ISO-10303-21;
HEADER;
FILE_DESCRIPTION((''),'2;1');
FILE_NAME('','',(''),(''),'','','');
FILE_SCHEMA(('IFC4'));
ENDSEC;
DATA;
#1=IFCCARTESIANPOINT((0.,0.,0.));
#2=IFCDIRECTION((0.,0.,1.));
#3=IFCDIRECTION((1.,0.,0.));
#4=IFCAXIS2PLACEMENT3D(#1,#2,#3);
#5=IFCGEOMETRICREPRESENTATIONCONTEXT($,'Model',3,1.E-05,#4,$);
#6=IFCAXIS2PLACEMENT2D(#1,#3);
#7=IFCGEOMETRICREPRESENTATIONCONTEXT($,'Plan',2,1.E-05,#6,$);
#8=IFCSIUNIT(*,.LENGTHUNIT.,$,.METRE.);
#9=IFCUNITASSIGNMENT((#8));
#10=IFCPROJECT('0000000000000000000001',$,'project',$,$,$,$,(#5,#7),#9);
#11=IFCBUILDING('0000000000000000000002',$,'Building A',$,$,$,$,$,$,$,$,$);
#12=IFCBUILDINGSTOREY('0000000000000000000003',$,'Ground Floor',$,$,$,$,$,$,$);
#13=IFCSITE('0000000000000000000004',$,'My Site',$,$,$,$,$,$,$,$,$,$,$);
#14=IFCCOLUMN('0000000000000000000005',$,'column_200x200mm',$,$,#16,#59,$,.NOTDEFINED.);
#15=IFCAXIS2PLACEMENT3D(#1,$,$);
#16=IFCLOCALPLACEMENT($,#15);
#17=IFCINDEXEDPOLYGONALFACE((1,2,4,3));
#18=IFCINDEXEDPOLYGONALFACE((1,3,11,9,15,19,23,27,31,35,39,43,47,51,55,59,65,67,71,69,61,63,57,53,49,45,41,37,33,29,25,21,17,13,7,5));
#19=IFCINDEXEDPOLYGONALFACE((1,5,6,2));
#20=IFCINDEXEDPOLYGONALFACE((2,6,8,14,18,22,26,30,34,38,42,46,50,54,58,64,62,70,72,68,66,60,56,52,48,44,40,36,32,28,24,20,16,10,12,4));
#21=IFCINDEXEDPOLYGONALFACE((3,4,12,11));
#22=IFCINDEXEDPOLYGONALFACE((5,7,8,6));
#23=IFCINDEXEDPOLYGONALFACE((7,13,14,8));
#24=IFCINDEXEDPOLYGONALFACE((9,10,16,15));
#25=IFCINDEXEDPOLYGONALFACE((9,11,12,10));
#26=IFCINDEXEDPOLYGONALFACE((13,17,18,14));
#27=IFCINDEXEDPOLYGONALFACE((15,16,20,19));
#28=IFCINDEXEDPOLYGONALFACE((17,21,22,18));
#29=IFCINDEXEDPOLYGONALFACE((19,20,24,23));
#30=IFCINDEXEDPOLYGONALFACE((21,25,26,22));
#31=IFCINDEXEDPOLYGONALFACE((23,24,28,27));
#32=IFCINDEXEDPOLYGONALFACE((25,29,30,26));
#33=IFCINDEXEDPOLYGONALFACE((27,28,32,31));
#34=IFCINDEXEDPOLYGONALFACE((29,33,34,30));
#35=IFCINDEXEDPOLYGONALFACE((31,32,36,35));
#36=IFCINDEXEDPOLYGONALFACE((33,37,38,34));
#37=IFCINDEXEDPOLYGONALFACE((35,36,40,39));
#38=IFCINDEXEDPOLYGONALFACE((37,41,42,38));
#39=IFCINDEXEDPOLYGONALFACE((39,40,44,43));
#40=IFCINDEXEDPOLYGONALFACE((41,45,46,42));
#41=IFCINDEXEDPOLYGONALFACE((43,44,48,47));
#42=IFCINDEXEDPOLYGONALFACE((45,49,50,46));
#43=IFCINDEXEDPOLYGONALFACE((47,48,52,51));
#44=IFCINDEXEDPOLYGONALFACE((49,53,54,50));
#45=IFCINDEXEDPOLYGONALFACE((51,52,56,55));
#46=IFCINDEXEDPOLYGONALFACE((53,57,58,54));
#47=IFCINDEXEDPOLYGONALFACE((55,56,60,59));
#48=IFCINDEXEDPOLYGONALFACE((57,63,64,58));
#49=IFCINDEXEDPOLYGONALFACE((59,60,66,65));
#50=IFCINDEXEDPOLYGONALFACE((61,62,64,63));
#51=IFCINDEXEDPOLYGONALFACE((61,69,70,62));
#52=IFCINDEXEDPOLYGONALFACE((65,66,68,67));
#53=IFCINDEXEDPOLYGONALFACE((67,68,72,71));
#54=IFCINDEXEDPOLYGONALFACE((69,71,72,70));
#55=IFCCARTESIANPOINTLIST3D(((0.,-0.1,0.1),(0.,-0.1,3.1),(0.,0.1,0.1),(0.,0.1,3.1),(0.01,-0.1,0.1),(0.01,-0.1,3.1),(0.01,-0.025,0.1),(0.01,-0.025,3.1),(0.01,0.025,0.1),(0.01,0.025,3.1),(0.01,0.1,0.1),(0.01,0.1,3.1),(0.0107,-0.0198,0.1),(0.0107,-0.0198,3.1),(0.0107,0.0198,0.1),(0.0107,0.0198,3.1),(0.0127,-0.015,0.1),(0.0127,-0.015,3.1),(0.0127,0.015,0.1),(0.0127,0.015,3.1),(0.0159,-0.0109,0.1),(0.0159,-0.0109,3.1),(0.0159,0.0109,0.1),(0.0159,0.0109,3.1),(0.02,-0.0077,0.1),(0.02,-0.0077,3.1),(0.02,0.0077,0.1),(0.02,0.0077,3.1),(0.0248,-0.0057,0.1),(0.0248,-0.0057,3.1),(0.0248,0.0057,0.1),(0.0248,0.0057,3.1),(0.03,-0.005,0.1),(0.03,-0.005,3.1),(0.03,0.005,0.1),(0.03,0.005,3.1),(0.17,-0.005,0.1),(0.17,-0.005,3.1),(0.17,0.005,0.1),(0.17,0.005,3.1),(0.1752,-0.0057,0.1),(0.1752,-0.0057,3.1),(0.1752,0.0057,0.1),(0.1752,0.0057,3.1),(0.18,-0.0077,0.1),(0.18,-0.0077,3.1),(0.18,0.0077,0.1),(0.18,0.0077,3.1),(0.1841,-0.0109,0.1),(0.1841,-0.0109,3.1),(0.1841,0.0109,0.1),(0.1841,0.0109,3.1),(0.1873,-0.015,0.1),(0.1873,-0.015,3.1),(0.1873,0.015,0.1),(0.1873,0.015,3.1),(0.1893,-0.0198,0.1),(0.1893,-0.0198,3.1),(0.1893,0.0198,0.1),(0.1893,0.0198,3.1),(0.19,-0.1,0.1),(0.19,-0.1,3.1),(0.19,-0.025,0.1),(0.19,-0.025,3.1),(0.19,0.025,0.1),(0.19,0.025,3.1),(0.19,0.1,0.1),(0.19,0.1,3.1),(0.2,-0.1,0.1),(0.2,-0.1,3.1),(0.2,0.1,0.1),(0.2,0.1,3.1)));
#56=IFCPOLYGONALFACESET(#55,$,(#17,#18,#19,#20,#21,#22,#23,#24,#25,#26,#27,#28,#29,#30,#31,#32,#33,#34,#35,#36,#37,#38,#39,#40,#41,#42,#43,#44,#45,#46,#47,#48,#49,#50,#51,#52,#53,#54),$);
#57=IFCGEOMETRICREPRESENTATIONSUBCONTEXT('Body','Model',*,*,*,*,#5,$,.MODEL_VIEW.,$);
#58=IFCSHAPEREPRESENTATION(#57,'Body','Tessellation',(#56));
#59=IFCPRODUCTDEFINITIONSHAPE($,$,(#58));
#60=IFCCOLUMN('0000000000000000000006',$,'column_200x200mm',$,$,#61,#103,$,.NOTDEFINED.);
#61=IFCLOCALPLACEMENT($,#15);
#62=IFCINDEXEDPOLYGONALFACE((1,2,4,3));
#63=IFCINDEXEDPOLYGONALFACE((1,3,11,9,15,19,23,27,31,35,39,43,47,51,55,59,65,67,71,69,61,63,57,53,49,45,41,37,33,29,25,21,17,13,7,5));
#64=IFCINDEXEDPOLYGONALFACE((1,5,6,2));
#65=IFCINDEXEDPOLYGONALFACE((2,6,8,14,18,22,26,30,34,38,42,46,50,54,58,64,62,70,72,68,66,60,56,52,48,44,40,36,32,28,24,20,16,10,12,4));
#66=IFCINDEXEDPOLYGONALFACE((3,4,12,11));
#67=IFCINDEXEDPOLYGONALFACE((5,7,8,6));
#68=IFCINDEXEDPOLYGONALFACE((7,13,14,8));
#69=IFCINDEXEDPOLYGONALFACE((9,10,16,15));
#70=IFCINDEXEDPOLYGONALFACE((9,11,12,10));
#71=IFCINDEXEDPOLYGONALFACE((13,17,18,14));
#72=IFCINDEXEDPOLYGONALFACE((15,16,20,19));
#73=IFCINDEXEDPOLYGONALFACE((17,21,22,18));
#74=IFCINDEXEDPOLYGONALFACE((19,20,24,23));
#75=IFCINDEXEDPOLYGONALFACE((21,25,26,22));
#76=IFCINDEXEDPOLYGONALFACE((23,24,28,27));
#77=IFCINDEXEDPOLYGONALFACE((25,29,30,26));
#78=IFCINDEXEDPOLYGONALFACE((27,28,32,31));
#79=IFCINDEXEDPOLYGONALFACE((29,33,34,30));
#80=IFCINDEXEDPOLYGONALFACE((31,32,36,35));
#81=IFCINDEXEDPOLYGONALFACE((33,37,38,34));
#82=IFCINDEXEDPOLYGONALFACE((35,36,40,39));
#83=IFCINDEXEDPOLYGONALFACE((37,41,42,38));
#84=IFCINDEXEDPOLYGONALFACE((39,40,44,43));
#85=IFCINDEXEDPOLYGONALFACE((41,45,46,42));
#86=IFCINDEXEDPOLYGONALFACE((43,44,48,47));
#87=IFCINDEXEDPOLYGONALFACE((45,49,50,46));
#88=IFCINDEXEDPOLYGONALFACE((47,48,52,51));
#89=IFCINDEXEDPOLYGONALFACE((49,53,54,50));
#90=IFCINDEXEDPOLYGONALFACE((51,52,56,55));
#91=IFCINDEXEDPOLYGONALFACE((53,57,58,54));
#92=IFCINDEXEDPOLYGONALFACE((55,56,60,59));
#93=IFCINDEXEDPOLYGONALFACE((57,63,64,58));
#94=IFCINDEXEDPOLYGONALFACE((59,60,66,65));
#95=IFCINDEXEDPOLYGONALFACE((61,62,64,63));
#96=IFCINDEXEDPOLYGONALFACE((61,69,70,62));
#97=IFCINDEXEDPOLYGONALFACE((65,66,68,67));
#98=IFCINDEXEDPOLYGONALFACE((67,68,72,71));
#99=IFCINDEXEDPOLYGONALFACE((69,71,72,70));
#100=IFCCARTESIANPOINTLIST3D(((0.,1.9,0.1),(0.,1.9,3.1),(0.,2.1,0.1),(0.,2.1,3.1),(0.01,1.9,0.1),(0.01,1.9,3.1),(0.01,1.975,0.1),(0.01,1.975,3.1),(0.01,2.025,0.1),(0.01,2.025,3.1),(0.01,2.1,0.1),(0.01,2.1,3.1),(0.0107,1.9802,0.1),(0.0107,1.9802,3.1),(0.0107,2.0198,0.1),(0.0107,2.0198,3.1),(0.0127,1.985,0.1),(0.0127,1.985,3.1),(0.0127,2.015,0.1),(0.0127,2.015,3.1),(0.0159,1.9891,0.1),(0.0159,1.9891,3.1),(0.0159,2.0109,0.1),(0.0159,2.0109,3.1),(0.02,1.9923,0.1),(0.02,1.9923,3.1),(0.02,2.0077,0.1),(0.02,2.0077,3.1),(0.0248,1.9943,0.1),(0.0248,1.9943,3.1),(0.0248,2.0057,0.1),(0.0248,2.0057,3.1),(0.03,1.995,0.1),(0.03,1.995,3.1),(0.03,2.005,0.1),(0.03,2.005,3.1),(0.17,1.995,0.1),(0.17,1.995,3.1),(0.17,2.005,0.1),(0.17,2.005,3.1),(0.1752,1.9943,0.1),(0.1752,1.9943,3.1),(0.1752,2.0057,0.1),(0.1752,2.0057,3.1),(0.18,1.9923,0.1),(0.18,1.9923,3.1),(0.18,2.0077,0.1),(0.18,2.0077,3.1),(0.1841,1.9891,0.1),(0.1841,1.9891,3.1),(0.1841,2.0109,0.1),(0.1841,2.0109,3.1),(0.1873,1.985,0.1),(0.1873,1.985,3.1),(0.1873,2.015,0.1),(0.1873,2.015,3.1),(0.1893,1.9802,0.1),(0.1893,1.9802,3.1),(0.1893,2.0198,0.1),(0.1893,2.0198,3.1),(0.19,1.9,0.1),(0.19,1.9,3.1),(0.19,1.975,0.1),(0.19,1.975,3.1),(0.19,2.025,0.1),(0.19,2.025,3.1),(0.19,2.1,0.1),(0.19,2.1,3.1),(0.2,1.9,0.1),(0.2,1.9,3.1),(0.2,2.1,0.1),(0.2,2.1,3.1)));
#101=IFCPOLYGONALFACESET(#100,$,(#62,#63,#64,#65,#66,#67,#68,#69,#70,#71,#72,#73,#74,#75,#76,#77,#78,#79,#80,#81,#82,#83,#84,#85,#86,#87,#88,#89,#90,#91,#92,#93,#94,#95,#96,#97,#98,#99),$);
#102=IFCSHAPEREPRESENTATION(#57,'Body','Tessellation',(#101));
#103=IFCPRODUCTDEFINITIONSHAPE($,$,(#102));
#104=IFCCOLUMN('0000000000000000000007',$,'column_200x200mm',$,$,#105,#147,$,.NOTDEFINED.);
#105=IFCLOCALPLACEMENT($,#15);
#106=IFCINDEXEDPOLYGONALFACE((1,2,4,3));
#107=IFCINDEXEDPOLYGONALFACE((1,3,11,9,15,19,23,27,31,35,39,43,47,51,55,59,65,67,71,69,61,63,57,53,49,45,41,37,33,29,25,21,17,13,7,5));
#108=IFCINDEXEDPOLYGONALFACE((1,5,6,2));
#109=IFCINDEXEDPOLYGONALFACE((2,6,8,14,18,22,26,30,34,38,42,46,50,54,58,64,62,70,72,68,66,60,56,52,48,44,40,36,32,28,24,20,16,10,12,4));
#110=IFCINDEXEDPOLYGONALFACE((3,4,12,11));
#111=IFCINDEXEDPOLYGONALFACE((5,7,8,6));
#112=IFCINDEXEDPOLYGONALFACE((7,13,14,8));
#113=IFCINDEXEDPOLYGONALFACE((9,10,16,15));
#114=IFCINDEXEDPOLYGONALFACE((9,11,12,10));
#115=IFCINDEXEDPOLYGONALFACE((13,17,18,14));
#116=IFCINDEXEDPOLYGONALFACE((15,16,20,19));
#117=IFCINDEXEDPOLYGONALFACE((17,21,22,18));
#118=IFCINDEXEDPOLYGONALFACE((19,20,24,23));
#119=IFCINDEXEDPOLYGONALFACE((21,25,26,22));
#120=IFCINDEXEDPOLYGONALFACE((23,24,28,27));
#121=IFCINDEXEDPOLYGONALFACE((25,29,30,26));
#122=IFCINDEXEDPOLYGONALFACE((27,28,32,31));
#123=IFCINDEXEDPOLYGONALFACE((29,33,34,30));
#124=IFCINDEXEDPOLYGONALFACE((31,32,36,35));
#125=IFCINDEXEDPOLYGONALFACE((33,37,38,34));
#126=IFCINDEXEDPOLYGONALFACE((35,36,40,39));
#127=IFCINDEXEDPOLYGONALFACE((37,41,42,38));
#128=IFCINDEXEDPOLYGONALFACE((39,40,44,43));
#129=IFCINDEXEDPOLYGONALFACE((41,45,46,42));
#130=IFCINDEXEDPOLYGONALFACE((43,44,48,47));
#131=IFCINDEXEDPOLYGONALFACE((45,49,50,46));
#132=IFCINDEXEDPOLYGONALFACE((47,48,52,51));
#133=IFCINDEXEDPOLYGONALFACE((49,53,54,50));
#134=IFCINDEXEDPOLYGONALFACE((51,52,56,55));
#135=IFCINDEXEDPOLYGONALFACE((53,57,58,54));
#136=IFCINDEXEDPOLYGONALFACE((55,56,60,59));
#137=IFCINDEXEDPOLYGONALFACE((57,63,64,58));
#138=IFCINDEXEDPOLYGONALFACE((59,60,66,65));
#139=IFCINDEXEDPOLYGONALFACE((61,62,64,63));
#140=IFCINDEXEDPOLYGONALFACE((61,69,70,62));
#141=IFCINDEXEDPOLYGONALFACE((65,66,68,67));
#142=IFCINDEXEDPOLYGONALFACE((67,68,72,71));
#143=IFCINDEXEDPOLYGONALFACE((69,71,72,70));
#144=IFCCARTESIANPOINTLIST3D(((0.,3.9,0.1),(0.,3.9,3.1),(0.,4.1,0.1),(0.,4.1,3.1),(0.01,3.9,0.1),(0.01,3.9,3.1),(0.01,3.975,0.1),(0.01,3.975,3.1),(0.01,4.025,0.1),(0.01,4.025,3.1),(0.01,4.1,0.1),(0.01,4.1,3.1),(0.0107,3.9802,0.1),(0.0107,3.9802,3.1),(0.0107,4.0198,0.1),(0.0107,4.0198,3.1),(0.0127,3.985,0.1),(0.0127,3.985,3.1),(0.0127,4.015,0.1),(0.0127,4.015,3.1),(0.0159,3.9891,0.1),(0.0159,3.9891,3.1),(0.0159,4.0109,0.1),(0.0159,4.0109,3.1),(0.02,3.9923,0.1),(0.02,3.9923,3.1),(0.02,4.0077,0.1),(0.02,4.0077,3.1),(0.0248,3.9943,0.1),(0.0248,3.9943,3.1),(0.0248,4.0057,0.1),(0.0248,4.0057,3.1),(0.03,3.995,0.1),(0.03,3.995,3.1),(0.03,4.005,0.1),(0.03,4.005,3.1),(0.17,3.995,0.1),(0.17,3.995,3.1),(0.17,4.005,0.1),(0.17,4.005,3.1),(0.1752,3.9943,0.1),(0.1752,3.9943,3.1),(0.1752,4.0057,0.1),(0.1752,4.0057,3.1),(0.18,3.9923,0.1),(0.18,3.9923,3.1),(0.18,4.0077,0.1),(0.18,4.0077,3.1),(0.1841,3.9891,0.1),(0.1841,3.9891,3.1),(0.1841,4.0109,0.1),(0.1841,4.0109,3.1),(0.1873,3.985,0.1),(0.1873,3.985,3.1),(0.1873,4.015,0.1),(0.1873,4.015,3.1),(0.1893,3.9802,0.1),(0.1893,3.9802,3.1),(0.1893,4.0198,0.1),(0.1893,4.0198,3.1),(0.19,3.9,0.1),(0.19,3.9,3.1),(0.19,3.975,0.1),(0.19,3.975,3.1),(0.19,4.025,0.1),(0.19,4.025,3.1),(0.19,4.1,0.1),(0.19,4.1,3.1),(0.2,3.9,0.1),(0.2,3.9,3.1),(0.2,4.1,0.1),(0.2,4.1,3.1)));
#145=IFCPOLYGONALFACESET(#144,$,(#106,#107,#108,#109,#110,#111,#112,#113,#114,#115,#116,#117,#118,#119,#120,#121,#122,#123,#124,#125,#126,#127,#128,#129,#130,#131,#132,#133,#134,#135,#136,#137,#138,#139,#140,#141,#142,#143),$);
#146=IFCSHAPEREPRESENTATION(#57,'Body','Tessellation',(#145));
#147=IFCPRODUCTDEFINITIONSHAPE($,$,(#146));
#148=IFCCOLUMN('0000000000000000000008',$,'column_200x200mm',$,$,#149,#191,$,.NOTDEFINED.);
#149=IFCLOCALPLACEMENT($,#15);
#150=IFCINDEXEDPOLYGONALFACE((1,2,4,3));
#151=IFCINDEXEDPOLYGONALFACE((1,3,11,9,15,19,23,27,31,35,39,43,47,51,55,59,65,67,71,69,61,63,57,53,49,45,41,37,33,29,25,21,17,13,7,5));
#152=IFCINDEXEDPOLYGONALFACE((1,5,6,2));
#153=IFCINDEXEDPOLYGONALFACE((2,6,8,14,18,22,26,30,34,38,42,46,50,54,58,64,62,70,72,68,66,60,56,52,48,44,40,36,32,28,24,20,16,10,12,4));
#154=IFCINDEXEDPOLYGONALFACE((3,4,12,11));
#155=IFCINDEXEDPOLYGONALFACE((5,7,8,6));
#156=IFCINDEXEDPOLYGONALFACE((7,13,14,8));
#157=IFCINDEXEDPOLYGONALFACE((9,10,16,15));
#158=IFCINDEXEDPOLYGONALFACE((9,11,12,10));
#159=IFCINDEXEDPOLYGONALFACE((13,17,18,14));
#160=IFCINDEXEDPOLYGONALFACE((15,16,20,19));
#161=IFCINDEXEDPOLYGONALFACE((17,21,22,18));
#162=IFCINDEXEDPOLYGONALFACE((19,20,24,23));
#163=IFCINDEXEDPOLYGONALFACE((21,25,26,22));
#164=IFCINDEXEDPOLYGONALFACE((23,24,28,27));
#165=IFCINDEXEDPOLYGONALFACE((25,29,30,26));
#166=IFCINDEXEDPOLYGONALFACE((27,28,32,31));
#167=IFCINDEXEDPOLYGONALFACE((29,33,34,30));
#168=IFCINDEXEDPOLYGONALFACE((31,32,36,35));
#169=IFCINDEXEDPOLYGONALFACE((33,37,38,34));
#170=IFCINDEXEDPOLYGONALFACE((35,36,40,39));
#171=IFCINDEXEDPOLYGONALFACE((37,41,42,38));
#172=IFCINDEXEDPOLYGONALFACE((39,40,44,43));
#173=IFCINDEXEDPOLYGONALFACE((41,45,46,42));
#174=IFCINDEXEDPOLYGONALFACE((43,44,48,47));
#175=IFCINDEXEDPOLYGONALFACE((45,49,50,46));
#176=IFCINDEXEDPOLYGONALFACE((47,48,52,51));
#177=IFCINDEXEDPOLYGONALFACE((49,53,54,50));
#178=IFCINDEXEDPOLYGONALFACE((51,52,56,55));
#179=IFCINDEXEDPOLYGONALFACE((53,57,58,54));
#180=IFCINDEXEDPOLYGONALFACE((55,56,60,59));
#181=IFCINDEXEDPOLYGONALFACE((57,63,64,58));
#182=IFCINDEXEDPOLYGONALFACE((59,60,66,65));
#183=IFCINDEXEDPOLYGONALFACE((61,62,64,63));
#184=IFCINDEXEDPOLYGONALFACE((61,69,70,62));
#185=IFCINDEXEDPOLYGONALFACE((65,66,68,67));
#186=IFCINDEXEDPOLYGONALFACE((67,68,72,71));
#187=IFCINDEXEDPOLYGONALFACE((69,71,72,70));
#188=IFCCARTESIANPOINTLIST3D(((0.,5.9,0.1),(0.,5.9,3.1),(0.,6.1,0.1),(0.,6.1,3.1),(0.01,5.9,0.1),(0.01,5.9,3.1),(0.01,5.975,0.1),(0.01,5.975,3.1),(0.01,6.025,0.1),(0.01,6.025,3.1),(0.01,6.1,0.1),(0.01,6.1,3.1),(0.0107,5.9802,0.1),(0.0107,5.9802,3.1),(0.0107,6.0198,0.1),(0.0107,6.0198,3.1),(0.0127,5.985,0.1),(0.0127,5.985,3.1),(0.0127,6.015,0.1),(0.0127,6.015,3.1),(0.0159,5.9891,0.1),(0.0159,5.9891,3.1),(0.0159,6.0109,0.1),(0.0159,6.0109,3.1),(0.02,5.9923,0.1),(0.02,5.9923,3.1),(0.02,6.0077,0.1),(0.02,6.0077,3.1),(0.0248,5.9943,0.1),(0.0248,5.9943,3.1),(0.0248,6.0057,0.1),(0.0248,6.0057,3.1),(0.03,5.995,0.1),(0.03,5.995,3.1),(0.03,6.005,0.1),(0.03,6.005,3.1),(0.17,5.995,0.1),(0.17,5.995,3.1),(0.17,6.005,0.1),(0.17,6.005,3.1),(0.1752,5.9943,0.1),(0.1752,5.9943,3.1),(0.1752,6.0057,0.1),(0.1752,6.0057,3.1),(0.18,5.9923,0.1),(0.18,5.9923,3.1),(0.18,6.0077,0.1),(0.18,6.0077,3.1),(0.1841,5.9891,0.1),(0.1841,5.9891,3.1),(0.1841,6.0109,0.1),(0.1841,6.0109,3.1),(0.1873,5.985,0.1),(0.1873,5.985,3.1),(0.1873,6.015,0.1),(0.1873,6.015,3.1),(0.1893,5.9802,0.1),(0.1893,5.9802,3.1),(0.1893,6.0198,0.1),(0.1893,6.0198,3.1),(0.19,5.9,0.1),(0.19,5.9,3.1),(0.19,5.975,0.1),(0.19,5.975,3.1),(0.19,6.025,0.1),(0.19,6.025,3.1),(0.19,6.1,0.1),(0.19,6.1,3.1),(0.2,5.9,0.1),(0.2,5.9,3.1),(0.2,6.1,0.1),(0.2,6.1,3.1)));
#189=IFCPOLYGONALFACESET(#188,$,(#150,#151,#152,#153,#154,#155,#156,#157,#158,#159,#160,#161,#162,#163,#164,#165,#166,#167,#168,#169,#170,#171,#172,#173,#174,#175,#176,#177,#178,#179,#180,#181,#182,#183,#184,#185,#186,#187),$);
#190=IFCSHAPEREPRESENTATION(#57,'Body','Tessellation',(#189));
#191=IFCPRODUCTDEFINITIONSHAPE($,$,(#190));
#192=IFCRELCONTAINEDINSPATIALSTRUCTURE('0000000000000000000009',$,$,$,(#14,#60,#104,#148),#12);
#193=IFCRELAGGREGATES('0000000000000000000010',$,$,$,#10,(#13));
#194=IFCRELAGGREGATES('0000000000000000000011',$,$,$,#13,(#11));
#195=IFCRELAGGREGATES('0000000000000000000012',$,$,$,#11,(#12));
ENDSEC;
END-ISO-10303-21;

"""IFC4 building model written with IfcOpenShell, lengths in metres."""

from ifc_helpers import new_model, entity, si_unit, frame, frame_2d, origin_with_axes, place, context, subcontext, project, spatial, extrude, element, save


model = new_model("IFC4")

# Units and contexts
model_context = context("Model", 3, precision=1e-05, world=origin_with_axes())
plan_context = context("Plan", 2, precision=1e-05, world=frame_2d((0.0, 0.0, 0.0), x_axis=(1.0, 0.0, 0.0)))
body_context = subcontext(model_context, "Body", "Model", "MODEL_VIEW")
ifc_project = project(units=[si_unit("LENGTHUNIT", "METRE")], contexts=[model_context, plan_context])

# Site, building, storey
site = spatial("IfcSite", under=ifc_project, Name="My Site")
building = spatial("IfcBuilding", under=site, Name="Building A")
storey = spatial("IfcBuildingStorey", under=building, Name="Ground Floor")

# Columns
for number, where, z_axis, x_axis, name in (
    (1, (0.1, 0.0, 0.1), (0.0, 0.0, 1.0), (0.0, 1.0, 0.0), "column_200x200mm"),
    (2, (0.1, 2.0, 0.1), (0.0, 0.0, 1.0), (0.0, 1.0, 0.0), "column_200x200mm"),
    (3, (0.1, 4.0, 0.1), (0.0, 0.0, 1.0), (0.0, 1.0, 0.0), "column_200x200mm"),
    (4, (0.1, 6.0, 0.1), (0.0, 0.0, 1.0), (0.0, 1.0, 0.0), "column_200x200mm"),
):
    element("IfcColumn", number, at=place(None, frame(where, z_axis=z_axis, x_axis=x_axis)), inside=storey, Name=name, PredefinedType="NOTDEFINED", context=body_context, shape_type="SweptSolid", body=[
        extrude(entity("IfcIShapeProfileDef", None, None, None, 0.2, 0.2, 0.01, 0.01, 0.02), origin_with_axes(), (0.0, 0.0, 1.0), 3.0),
    ])

save(model, "model.ifc")
